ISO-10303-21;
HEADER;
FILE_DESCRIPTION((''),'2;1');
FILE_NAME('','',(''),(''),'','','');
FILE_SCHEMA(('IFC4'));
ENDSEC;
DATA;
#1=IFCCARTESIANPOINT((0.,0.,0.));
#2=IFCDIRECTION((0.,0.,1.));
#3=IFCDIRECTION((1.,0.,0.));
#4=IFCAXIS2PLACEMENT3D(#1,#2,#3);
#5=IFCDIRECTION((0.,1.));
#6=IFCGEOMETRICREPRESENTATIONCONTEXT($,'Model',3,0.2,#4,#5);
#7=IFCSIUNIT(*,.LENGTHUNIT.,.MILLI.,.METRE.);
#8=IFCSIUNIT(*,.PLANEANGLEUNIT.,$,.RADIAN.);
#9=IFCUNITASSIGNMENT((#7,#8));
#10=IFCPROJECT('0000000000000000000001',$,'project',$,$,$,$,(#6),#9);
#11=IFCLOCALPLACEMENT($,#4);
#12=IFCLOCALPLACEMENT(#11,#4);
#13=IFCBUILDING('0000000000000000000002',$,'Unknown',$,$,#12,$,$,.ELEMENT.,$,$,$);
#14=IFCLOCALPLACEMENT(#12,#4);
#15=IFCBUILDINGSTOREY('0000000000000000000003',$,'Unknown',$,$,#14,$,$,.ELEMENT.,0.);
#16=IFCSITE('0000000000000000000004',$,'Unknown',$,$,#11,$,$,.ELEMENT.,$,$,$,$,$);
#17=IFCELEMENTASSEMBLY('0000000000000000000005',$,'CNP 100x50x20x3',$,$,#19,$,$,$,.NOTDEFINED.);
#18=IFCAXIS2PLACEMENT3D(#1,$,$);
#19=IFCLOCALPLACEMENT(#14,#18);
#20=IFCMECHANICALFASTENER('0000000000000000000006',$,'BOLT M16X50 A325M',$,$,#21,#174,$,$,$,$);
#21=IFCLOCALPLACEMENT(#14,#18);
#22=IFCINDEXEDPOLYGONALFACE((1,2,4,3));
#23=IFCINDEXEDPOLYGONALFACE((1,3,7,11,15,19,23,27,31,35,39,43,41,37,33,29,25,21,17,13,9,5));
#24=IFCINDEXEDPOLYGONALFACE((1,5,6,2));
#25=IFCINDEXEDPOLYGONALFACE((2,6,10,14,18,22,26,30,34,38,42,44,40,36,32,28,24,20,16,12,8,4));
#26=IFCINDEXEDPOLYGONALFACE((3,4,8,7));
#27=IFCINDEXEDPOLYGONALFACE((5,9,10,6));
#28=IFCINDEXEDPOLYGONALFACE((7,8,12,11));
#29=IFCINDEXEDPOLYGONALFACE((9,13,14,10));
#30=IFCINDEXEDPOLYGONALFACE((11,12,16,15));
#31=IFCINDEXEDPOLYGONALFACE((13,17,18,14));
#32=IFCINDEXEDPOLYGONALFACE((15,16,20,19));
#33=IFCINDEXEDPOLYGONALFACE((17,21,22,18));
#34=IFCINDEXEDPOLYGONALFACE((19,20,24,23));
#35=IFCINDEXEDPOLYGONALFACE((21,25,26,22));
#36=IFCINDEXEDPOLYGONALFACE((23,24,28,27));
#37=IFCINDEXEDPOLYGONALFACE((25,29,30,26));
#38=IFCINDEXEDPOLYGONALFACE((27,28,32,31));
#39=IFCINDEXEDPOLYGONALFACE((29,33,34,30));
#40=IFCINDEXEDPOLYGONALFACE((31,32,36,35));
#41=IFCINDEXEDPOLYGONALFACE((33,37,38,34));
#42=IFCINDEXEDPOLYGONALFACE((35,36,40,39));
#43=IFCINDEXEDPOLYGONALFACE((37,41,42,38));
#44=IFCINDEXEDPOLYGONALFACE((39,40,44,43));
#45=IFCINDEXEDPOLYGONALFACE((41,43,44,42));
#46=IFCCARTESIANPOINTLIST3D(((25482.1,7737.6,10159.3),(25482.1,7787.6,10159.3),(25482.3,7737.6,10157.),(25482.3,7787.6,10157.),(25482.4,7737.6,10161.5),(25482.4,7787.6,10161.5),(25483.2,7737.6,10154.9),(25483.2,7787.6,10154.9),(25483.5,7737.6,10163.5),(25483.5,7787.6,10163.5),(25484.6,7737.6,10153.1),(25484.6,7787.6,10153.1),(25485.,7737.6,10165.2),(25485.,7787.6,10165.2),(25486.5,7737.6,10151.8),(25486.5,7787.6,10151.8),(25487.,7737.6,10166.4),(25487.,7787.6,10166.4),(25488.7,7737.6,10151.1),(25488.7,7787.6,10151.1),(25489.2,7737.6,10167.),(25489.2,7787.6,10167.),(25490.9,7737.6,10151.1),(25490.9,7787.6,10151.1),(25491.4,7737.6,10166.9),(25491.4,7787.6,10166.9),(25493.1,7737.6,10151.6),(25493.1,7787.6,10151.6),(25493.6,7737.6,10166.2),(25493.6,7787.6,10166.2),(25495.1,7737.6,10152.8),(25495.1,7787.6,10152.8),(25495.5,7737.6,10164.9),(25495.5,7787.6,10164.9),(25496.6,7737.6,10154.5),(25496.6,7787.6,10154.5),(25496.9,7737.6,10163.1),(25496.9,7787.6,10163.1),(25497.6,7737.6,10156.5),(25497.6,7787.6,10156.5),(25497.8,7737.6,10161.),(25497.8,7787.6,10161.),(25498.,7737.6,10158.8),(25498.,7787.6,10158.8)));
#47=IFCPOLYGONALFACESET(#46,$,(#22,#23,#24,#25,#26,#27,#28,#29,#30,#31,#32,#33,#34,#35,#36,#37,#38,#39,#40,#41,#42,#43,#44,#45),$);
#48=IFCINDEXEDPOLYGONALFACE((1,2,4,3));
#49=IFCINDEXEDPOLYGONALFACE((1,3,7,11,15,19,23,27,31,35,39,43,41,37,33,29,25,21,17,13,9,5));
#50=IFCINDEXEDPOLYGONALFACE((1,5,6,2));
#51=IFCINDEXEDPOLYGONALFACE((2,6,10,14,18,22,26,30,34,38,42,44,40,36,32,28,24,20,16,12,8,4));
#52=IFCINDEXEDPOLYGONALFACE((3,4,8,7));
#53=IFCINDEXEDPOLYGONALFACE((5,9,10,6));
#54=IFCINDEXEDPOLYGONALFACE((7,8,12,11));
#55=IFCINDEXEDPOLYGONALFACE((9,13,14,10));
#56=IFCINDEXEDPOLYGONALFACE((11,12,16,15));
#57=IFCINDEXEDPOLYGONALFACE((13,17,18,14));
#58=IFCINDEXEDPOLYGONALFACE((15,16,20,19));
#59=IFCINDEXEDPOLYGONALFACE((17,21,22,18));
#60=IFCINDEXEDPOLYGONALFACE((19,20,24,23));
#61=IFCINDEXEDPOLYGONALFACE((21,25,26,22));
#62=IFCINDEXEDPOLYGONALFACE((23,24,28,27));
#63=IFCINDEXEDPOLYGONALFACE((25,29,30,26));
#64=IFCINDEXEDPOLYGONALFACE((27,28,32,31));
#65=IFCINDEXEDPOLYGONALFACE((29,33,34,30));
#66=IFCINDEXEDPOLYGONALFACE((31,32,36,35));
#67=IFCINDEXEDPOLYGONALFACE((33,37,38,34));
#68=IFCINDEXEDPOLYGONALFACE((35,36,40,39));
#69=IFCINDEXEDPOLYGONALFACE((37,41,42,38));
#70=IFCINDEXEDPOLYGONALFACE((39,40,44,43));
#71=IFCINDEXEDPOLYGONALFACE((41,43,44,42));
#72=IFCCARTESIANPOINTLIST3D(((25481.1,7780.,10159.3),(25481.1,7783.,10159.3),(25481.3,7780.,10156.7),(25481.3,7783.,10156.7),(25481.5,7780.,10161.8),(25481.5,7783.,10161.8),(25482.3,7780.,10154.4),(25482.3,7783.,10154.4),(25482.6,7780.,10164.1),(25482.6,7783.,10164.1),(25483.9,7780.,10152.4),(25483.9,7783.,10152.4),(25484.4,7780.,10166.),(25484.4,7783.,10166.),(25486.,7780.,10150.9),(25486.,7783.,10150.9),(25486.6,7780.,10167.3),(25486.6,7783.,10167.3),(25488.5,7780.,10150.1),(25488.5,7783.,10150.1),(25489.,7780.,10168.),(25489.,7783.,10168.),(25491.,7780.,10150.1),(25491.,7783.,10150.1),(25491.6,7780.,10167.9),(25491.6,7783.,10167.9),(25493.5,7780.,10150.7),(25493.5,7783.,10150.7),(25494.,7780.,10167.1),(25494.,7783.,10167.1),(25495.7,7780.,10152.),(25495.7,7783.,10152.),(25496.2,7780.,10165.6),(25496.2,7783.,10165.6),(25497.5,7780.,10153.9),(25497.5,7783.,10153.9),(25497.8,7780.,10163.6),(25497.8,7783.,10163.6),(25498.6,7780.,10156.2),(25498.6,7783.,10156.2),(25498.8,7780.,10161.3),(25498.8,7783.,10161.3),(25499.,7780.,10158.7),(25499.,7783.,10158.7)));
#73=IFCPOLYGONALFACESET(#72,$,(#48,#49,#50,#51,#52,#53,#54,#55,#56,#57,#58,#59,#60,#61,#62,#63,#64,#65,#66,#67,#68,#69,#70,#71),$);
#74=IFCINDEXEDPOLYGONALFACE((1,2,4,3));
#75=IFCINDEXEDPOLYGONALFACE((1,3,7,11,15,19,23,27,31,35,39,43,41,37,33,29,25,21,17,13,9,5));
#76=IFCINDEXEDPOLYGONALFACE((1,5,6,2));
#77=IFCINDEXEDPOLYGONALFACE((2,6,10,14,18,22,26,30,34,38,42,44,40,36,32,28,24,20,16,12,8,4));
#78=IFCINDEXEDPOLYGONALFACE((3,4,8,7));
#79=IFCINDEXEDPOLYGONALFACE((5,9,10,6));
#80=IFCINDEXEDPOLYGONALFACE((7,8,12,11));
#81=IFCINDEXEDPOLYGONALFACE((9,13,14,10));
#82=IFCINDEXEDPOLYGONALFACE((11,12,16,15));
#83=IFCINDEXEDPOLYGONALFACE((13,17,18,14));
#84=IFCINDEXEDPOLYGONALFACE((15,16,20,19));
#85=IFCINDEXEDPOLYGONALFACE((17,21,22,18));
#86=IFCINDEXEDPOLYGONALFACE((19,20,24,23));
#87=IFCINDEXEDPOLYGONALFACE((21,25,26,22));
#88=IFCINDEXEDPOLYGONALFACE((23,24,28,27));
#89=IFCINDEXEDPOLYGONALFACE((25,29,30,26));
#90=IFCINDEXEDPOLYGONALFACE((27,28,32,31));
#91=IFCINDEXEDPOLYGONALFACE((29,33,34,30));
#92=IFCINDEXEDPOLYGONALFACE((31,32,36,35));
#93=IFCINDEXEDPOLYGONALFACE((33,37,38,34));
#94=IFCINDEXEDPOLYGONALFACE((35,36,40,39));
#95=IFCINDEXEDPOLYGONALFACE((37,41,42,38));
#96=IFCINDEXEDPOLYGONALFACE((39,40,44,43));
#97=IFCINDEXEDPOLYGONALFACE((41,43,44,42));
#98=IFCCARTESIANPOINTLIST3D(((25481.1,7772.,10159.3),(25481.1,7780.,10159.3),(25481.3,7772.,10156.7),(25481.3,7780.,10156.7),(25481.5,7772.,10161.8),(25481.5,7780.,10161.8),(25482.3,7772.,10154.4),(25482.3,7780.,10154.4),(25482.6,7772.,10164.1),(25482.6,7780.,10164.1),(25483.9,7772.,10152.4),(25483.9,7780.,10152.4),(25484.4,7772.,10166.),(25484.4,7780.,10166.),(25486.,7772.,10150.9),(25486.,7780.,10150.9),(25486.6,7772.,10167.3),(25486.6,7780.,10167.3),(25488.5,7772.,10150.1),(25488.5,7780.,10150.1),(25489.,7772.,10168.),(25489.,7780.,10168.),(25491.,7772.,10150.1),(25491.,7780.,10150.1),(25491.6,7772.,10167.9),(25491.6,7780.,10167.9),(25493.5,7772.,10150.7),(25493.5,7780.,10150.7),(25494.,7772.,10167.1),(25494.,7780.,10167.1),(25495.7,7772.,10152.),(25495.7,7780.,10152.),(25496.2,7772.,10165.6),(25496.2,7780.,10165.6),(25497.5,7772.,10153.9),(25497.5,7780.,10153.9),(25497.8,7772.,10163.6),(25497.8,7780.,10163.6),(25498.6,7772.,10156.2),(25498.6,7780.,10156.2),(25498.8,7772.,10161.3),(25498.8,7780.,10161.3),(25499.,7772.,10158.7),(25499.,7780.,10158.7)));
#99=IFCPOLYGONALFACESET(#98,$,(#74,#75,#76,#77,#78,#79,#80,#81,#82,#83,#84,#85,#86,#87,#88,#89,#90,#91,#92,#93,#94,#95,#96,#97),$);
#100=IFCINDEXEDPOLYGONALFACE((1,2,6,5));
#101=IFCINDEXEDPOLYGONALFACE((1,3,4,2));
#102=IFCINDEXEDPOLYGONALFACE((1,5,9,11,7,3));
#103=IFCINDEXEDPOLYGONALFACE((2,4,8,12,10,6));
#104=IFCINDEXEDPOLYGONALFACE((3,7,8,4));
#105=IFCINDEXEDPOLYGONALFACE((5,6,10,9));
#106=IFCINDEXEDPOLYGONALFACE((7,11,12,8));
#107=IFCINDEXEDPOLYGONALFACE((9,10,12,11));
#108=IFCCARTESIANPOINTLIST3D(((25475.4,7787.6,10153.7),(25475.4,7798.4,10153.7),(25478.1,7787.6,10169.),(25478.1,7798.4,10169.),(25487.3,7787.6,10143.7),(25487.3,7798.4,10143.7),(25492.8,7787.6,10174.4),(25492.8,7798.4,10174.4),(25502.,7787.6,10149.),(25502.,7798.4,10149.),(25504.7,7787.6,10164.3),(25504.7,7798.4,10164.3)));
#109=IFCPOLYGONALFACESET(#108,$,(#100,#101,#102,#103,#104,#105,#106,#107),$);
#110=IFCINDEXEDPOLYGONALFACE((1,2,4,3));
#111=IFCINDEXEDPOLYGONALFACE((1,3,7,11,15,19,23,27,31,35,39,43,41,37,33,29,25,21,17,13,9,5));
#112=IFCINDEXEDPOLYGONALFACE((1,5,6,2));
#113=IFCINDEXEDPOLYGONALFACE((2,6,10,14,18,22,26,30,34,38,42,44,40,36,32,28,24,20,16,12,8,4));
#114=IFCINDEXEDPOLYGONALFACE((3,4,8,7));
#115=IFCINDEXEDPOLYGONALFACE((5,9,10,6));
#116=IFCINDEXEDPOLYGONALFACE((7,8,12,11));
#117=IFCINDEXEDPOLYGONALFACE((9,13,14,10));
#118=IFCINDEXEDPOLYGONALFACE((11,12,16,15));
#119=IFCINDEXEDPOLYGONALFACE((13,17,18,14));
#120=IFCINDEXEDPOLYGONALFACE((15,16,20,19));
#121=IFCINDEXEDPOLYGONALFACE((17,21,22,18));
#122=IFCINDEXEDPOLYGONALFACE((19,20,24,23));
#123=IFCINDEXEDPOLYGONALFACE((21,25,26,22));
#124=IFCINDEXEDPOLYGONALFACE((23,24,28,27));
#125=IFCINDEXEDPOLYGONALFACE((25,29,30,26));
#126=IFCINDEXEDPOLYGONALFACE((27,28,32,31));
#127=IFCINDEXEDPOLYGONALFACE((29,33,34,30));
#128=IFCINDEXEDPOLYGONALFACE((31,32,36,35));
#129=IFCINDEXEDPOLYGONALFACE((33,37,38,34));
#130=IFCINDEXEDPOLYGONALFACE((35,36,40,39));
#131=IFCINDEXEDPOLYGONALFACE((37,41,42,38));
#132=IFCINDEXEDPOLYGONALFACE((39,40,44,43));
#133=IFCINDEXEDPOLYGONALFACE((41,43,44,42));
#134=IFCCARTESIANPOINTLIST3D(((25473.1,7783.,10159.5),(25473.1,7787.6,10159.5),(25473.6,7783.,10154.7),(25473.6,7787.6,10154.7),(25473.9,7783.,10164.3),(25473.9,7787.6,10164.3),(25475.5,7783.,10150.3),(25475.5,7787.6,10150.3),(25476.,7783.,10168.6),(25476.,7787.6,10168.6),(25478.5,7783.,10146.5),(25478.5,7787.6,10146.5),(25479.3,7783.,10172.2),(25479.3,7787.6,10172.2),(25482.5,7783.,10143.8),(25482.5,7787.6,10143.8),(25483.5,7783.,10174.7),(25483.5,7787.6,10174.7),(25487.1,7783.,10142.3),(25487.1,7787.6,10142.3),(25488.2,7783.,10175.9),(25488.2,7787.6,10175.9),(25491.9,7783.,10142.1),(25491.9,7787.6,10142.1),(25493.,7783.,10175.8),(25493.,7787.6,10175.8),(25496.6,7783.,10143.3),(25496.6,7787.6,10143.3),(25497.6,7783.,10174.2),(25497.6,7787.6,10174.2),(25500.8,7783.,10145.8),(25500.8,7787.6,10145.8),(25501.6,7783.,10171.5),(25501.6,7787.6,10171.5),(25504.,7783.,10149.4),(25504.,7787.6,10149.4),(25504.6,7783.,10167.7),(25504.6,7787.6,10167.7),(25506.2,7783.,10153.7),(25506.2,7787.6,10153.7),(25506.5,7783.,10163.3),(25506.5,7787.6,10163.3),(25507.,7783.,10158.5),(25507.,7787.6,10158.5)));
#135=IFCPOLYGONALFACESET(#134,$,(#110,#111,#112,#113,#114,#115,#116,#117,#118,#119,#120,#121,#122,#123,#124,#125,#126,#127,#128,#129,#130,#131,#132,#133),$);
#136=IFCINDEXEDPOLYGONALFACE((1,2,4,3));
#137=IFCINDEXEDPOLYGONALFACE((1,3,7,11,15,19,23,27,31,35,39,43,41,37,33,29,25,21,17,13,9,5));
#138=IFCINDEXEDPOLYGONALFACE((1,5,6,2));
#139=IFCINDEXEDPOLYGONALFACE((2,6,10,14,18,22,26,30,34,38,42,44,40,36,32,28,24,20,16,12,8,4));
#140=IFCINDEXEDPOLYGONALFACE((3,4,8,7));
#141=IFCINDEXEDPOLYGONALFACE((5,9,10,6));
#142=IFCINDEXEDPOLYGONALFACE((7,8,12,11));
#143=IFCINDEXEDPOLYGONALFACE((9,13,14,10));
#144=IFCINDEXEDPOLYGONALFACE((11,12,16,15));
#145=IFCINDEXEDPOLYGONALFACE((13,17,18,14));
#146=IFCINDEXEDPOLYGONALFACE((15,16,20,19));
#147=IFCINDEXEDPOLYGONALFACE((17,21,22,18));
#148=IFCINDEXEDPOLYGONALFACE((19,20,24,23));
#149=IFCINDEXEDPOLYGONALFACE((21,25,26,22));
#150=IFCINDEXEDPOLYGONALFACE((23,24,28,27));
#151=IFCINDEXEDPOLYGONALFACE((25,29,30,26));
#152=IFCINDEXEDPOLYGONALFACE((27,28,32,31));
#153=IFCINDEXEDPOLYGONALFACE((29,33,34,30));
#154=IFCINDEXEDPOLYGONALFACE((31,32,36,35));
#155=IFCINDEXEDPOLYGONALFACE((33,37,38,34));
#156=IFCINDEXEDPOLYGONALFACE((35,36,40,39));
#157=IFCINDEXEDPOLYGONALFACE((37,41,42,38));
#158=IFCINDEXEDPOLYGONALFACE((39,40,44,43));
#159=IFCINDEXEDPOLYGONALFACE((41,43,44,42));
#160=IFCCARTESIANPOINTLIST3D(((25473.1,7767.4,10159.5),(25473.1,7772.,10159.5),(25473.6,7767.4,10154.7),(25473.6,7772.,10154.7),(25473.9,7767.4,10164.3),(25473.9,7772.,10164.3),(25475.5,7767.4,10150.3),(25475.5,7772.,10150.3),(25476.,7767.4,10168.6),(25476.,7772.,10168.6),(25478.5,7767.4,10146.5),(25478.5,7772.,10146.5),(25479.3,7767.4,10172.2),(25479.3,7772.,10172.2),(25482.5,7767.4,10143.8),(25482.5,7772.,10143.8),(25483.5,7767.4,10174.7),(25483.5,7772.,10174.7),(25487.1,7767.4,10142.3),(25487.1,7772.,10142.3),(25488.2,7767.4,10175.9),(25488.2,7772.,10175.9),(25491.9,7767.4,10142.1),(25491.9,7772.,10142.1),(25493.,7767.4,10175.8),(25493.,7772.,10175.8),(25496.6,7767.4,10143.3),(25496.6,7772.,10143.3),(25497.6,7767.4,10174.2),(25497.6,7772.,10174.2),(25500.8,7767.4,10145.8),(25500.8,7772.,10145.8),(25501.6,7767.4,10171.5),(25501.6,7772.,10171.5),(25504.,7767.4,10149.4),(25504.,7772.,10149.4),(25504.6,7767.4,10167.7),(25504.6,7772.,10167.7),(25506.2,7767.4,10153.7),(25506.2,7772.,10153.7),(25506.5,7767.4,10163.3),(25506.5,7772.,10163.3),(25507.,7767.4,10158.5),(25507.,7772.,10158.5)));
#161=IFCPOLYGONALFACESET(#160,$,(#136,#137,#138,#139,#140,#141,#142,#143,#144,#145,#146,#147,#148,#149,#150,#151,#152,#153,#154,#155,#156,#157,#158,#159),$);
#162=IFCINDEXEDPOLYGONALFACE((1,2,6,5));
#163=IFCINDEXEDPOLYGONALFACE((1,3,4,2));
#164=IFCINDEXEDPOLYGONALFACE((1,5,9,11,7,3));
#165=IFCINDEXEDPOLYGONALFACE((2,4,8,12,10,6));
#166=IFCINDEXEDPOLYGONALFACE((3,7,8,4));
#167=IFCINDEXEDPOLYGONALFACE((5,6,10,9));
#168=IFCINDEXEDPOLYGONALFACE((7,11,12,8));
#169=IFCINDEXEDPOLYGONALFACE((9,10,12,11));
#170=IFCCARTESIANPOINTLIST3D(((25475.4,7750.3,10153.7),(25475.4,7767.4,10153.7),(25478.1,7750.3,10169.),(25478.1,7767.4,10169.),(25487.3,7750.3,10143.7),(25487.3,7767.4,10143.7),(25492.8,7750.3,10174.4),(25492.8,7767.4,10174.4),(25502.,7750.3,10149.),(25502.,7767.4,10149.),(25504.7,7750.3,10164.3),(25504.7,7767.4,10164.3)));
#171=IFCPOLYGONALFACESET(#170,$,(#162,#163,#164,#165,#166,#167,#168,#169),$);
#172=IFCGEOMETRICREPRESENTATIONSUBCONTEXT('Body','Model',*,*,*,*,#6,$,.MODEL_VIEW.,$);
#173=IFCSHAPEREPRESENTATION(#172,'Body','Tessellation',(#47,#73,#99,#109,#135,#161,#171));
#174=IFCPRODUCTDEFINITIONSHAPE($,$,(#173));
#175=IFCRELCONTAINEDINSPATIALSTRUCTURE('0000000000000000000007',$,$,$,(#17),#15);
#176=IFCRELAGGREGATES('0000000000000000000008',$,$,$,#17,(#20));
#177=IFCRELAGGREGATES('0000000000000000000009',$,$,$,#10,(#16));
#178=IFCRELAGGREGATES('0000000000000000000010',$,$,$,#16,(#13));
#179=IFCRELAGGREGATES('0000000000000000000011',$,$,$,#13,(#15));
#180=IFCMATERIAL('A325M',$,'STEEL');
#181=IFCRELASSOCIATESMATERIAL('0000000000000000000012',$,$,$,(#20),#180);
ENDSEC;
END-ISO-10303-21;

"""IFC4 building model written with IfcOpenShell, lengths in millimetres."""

from ifc_helpers import new_model, si_unit, direction, frame, origin_with_axes, place, context, subcontext, project, spatial, line, arc, indexed_curve, outline, extrude, source, transform, mapped, material, element, aggregate, save


model = new_model("IFC4")

# Units and contexts
model_context = context("Model", 3, precision=0.2, world=origin_with_axes(), true_north=direction((0.0, 1.0)))
body_context = subcontext(model_context, "Body", "Model", "MODEL_VIEW")
ifc_project = project(units=[si_unit("LENGTHUNIT", "METRE", prefix="MILLI"), si_unit("PLANEANGLEUNIT", "RADIAN")], contexts=[model_context])

# Site, building, storey
site_placement = place(None, origin_with_axes())
site = spatial("IfcSite", under=ifc_project, at=site_placement, Name="Unknown", CompositionType="ELEMENT")
building_placement = place(site_placement, origin_with_axes())
building = spatial("IfcBuilding", under=site, at=building_placement, Name="Unknown", CompositionType="ELEMENT")
storey_placement = place(building_placement, origin_with_axes())
storey = spatial("IfcBuildingStorey", under=building, at=storey_placement, Name="Unknown", CompositionType="ELEMENT", Elevation=0.0)

# Element assembly
assembly_1_placement = place(storey_placement, frame((25552.5, 7805.0, 10153.1), z_axis=(0.173648, 0.0, 0.984808), x_axis=(-0.984808, 0.0, 0.173648)))
assembly_1 = element("IfcElementAssembly", 1, at=assembly_1_placement, inside=storey, Name="CNP 100x50x20x3", PredefinedType="NOTDEFINED")

# Mechanical fastener
ifc_material_1 = material(Name="A325M", Category="STEEL")
shared_shape_1 = source(origin_with_axes(), body_context, "Body", "SweptSolid", [
    extrude(outline(indexed_curve([(8.0, 0.0), (0.0, 8.0), (-8.0, 0.0), (0.0, -8.0)], segments=[arc(1, 2, 3), arc(3, 4, 1)])), frame((0.0, 0.0, 15.6), z_axis=(0.0, 0.0, -1.0), x_axis=(0.0, 1.0, 0.0)), (0.0, 0.0, 1.0), 50.0),
    extrude(outline(indexed_curve([(9.0, 0.0), (0.0, 9.0), (-9.0, 0.0), (0.0, -9.0)], segments=[arc(1, 2, 3), arc(3, 4, 1)])), frame((0.0, 0.0, 11.0), z_axis=(0.0, 0.0, -1.0), x_axis=(0.0, 1.0, 0.0)), (0.0, 0.0, 1.0), 3.0),
    extrude(outline(indexed_curve([(9.0, 0.0), (0.0, 9.0), (-9.0, 0.0), (0.0, -9.0)], segments=[arc(1, 2, 3), arc(3, 4, 1)])), frame((0.0, 0.0, 8.0), z_axis=(0.0, 0.0, -1.0), x_axis=(0.0, 1.0, 0.0)), (0.0, 0.0, 1.0), 8.0),
    extrude(outline(indexed_curve([(15.6, 0.0), (7.8, 13.5), (-7.8, 13.5), (-15.6, 0.0), (-7.8, -13.5), (7.8, -13.5)], segments=[line(1, 2, 3, 4, 5, 6, 1)])), frame((0.0, 0.0, 26.4), z_axis=(0.0, 0.0, -1.0), x_axis=(0.0, 1.0, 0.0)), (0.0, 0.0, 1.0), 10.8),
    extrude(outline(indexed_curve([(17.0, 0.0), (0.0, 17.0), (-17.0, 0.0), (0.0, -17.0)], segments=[arc(1, 2, 3), arc(3, 4, 1)])), frame((0.0, 0.0, 15.6), z_axis=(0.0, 0.0, -1.0), x_axis=(0.0, 1.0, 0.0)), (0.0, 0.0, 1.0), 4.6),
    extrude(outline(indexed_curve([(17.0, 0.0), (0.0, 17.0), (-17.0, 0.0), (0.0, -17.0)], segments=[arc(1, 2, 3), arc(3, 4, 1)])), frame((0.0, 0.0, 0.0), z_axis=(0.0, 0.0, -1.0), x_axis=(0.0, 1.0, 0.0)), (0.0, 0.0, 1.0), 4.6),
    extrude(outline(indexed_curve([(15.6, 0.0), (7.8, 13.5), (-7.8, 13.5), (-15.6, 0.0), (-7.8, -13.5), (7.8, -13.5)], segments=[line(1, 2, 3, 4, 5, 6, 1)])), frame((0.0, 0.0, -4.6), z_axis=(0.0, 0.0, -1.0), x_axis=(0.0, 1.0, 0.0)), (0.0, 0.0, 1.0), 17.1),
])
mechanical_fastener_1_placement = place(assembly_1_placement, frame((62.5, 33.0, -5.0), z_axis=(0.0, -1.0, 0.0), x_axis=(-1.0, 0.0, 0.0)))
mechanical_fastener_1 = element("IfcMechanicalFastener", 2, at=mechanical_fastener_1_placement, material=ifc_material_1, Name="BOLT M16X50 A325M", context=body_context, shape_type="MappedRepresentation", body=[
    mapped(shared_shape_1, transform((0.0, 0.0, 0.0))),
])
aggregate(assembly_1, [mechanical_fastener_1])

save(model, "model.ifc")
